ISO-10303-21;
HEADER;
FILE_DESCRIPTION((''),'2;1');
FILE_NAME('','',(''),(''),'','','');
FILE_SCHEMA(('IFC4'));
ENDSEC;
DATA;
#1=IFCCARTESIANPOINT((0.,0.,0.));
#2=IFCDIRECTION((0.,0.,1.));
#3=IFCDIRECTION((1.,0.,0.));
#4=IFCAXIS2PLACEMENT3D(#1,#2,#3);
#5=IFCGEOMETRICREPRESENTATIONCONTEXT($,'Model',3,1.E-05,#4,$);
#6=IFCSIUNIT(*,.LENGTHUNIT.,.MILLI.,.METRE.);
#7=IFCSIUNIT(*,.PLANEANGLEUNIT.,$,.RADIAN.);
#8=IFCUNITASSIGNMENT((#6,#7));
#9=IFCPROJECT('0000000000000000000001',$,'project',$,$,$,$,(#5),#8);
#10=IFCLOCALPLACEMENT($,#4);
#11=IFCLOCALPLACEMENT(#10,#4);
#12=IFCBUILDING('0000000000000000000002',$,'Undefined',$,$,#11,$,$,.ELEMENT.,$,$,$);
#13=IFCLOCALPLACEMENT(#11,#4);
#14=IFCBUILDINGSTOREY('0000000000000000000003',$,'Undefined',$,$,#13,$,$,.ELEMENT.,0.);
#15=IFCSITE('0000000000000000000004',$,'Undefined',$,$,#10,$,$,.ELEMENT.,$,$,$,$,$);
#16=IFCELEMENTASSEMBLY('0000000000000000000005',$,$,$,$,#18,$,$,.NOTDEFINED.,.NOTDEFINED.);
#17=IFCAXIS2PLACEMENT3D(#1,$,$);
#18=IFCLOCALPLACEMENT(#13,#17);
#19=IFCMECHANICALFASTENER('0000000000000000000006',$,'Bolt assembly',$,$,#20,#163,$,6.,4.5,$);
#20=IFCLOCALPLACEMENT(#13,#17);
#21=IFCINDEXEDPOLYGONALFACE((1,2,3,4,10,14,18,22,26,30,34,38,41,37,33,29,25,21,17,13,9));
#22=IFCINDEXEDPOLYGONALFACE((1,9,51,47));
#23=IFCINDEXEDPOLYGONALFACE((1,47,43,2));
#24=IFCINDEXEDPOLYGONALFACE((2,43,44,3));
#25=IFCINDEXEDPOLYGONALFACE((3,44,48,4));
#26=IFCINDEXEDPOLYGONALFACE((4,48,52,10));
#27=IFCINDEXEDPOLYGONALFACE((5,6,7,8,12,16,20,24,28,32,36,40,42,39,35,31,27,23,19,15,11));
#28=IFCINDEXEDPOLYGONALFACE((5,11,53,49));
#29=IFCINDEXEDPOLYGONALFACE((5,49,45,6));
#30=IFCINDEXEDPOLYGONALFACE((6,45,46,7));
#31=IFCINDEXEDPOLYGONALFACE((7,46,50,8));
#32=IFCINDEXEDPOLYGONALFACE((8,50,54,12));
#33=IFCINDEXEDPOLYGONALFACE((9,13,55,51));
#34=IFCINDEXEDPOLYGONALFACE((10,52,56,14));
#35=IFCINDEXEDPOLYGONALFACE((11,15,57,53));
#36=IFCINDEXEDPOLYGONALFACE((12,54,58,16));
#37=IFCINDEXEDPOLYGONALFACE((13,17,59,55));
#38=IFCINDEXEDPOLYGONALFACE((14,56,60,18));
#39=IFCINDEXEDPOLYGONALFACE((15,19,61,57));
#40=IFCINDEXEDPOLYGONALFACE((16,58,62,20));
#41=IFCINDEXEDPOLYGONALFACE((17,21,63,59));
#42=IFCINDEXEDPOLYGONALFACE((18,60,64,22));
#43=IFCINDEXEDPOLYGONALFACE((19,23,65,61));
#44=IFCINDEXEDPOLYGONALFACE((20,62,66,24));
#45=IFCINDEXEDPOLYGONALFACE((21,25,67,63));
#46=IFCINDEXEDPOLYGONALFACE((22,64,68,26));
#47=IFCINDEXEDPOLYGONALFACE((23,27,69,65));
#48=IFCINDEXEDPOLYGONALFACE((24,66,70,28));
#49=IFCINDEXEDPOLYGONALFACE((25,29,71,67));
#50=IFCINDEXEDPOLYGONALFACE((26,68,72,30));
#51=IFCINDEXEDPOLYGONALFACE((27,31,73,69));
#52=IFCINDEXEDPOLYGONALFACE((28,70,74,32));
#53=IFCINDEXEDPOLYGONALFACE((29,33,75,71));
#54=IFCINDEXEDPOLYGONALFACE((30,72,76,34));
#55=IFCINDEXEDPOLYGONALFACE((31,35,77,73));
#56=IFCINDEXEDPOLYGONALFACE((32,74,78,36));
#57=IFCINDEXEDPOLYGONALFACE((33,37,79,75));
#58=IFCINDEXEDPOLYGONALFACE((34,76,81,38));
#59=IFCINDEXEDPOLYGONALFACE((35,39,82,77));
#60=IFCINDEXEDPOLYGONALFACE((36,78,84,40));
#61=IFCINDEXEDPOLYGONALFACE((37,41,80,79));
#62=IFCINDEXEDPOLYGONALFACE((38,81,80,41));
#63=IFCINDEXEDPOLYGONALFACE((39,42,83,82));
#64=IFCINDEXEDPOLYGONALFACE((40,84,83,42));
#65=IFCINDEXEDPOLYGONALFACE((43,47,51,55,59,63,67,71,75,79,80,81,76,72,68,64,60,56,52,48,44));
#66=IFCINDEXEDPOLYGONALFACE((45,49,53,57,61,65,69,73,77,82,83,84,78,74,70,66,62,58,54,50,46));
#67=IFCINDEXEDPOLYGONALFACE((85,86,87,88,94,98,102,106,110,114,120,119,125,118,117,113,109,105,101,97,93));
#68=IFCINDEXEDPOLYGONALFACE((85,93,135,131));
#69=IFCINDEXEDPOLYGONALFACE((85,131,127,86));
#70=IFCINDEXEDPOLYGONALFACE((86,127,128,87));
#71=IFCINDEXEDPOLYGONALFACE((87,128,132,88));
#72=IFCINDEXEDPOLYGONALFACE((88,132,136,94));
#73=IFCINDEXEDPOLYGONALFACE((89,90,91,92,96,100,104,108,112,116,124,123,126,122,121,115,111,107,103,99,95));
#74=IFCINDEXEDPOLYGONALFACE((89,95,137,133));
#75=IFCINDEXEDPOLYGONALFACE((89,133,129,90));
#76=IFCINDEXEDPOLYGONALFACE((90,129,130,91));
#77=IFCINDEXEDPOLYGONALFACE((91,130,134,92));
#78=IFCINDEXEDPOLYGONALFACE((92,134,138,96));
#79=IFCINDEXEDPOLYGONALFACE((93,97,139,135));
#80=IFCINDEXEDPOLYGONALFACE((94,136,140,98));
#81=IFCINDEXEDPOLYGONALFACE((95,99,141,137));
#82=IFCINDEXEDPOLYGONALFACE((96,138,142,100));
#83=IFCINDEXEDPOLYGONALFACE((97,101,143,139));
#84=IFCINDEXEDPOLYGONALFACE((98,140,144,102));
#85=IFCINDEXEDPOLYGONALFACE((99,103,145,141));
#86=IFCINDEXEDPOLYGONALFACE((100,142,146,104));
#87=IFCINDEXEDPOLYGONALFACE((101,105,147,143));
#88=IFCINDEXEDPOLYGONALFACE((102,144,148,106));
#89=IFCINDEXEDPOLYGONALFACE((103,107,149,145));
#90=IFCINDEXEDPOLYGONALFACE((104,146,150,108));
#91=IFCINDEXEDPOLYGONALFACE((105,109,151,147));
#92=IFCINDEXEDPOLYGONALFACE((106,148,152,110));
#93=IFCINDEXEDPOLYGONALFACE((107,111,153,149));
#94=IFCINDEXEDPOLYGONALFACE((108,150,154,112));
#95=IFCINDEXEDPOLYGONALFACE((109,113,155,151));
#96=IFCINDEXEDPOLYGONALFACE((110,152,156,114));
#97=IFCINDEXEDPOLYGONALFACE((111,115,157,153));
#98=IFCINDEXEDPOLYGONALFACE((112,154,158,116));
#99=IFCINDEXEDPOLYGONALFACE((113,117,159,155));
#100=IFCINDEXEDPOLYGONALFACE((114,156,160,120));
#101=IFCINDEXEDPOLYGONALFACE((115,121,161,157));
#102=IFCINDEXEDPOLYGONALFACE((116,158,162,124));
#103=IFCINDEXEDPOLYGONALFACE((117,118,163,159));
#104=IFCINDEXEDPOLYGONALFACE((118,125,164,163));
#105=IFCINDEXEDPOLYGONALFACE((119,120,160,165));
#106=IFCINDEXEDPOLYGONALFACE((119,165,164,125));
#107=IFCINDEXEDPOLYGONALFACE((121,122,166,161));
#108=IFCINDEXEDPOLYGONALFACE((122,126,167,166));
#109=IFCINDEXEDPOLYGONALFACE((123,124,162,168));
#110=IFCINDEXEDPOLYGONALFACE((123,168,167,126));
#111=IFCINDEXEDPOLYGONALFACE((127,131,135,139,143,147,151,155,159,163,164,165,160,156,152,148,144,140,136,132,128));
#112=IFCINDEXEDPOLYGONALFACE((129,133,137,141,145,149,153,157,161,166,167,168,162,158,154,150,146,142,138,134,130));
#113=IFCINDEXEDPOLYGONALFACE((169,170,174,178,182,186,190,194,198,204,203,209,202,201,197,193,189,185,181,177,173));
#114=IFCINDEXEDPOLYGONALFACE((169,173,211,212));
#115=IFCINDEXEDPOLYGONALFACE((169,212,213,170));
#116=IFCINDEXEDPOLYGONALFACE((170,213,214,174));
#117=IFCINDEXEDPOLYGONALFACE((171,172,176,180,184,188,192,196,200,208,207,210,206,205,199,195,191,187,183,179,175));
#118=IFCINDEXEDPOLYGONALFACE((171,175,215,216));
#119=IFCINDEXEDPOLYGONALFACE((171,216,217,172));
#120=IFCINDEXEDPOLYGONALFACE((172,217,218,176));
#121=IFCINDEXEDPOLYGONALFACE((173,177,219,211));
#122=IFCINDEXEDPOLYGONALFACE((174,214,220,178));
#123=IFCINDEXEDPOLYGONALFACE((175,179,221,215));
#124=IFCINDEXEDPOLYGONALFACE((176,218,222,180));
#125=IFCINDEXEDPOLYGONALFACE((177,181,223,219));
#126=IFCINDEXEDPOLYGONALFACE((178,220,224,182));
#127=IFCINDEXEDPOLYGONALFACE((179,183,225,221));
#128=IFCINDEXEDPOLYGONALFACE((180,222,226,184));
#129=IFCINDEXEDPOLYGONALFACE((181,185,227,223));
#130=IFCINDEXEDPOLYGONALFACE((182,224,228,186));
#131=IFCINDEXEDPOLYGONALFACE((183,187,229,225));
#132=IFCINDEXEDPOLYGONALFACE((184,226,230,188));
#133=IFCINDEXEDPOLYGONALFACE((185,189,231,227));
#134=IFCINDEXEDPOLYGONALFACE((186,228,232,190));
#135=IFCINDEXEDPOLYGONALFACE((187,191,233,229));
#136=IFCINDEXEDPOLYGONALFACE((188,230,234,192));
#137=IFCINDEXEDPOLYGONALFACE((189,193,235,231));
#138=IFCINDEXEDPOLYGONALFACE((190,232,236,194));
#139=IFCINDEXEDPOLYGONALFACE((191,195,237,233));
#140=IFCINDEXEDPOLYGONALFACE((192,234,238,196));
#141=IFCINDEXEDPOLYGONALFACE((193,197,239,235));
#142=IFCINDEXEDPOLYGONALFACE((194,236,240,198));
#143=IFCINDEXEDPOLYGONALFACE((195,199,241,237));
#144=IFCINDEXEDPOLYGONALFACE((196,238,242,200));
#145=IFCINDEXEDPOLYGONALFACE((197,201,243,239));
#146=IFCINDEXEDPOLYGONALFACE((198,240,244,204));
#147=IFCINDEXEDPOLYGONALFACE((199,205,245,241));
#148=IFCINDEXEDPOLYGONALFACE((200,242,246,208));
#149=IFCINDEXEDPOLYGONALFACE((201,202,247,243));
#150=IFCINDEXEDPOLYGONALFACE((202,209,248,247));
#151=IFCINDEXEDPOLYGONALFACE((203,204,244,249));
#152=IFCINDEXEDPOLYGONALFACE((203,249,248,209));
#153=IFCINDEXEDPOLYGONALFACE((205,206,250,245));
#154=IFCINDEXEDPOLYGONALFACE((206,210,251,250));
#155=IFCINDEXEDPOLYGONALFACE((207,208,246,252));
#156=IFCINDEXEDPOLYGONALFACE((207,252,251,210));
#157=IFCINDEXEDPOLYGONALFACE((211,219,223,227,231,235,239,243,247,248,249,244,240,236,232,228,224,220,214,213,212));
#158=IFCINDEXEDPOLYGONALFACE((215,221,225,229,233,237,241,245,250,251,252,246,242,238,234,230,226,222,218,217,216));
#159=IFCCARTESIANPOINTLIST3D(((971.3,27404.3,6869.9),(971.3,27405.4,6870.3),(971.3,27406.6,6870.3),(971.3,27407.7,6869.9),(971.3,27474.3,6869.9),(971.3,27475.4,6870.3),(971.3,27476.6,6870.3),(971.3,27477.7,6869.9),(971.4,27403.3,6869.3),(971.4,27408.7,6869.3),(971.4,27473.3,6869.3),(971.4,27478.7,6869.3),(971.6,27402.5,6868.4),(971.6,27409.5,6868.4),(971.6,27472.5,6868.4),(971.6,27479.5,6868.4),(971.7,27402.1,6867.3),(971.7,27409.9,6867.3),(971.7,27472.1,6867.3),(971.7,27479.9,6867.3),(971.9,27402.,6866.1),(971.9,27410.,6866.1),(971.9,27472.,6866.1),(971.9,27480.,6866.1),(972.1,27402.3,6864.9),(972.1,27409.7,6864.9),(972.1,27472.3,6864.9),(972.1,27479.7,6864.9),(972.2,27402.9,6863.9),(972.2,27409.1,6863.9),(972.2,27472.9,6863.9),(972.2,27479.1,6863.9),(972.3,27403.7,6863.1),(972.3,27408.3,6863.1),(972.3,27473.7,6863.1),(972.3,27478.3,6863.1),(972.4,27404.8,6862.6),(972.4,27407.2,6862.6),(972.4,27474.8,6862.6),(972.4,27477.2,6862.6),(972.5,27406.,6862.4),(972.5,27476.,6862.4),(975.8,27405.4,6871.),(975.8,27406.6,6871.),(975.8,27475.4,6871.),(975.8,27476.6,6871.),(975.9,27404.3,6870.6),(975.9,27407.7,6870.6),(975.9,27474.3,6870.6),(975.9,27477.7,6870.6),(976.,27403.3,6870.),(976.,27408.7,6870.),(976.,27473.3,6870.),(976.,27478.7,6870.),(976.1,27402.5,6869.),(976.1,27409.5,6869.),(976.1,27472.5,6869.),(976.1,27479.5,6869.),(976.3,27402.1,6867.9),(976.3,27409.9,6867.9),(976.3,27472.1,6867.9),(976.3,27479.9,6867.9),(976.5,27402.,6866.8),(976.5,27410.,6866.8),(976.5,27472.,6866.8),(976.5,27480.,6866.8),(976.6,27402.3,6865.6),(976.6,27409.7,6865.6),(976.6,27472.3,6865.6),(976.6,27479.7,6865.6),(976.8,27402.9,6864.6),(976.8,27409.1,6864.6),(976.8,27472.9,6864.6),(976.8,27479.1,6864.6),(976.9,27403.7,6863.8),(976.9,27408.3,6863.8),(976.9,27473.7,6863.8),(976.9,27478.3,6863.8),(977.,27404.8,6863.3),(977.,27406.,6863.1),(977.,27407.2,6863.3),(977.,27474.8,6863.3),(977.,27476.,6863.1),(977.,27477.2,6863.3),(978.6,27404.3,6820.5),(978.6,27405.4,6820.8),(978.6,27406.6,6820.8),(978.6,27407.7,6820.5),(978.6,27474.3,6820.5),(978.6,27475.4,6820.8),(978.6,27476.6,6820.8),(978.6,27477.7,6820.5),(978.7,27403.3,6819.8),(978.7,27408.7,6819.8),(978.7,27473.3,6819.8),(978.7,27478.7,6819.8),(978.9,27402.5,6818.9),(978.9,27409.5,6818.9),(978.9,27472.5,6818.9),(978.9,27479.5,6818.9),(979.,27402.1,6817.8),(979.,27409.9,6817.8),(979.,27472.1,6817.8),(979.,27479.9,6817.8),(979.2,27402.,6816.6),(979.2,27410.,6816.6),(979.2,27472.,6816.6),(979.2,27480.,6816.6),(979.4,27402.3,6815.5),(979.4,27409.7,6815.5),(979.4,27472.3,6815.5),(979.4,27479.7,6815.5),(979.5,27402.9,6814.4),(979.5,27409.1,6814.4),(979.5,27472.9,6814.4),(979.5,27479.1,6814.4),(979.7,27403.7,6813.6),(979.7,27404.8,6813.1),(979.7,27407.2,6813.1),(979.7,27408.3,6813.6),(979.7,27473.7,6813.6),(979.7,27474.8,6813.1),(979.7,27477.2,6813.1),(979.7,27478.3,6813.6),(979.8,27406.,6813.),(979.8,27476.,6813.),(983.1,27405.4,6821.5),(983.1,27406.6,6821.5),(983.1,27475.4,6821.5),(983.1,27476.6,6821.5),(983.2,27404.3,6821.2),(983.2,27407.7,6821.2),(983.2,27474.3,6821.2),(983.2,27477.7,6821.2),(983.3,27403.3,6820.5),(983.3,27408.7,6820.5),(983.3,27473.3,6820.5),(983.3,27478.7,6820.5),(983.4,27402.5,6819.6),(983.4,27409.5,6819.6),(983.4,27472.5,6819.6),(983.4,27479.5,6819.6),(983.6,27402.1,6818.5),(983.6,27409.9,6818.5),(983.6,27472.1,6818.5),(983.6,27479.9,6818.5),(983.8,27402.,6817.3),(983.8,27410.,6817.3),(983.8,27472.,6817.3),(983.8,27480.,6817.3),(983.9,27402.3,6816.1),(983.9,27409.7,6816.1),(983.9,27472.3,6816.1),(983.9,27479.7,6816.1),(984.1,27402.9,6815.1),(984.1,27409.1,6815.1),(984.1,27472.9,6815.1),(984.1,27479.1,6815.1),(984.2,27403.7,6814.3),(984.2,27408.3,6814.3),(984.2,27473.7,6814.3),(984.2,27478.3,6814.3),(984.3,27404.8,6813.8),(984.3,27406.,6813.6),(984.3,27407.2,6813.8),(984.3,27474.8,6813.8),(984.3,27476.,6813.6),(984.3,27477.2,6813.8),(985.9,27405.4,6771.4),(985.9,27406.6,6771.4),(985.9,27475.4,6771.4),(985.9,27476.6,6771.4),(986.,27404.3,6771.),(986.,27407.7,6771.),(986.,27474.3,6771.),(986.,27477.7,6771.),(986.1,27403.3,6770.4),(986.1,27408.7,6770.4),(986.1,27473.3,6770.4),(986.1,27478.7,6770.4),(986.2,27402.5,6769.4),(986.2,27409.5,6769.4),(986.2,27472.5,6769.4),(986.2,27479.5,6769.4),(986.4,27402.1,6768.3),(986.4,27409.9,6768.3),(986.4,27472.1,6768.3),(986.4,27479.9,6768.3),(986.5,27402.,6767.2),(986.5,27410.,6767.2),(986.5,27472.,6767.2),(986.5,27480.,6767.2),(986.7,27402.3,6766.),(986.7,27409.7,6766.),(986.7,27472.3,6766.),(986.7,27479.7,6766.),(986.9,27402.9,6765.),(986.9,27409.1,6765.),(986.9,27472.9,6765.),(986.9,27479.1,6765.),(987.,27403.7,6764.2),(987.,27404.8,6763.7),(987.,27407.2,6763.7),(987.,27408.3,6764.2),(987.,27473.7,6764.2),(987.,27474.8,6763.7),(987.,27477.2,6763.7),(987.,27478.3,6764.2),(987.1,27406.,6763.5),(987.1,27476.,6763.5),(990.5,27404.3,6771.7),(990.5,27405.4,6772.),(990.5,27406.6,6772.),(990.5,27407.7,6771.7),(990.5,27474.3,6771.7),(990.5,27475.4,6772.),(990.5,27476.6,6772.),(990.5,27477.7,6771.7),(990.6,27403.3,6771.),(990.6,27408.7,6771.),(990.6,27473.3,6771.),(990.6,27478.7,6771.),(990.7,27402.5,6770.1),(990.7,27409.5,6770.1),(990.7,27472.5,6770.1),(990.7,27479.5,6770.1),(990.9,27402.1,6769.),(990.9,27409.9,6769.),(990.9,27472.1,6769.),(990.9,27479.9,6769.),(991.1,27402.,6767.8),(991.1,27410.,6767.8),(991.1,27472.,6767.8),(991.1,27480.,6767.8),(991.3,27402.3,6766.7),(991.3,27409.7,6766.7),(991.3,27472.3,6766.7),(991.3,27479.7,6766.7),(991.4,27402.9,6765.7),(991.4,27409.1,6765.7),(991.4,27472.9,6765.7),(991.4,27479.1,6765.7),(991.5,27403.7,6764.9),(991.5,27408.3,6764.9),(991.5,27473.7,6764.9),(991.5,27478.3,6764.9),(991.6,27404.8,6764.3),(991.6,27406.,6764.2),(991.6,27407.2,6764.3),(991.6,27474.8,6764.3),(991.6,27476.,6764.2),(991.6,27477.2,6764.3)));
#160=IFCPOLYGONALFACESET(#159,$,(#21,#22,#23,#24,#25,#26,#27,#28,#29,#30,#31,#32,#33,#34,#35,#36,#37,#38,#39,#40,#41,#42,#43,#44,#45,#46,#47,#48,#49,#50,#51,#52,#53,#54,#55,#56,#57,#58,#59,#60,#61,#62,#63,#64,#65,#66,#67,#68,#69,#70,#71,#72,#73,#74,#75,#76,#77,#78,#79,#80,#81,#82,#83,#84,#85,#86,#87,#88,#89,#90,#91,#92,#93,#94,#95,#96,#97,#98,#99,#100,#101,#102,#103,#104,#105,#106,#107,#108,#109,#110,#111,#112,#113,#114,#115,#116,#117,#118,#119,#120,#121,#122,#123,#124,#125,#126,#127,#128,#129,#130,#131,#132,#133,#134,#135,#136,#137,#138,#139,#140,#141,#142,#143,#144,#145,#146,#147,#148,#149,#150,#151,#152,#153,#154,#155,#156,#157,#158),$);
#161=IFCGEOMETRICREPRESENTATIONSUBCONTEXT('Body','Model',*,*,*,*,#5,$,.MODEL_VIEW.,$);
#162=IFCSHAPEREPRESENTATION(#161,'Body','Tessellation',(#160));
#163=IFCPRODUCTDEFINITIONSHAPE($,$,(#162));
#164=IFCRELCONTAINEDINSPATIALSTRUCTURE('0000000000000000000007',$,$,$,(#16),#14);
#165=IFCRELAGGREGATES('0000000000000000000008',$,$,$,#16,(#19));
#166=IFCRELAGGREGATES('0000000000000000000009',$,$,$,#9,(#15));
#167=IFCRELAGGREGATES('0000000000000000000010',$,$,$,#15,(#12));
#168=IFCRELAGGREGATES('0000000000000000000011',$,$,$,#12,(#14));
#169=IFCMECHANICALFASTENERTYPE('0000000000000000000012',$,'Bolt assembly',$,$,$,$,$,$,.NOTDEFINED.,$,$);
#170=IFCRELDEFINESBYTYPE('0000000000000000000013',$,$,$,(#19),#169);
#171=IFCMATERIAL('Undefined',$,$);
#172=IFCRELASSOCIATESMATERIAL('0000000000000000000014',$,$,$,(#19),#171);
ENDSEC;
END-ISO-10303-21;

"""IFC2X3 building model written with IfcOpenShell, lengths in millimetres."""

from ifc_helpers import new_model, si_unit, frame, origin_with_axes, origin_2d_with_axis, place, context, subcontext, project, spatial, circle, extrude, source, transform, mapped, material, type_object, element, aggregate, save


model = new_model("IFC2X3")

# Units and contexts
model_context = context("Model", 3, precision=1e-05, world=origin_with_axes())
body_context = subcontext(model_context, "Body", "Model", "MODEL_VIEW")
ifc_project = project(units=[si_unit("LENGTHUNIT", "METRE", prefix="MILLI"), si_unit("PLANEANGLEUNIT", "RADIAN")], contexts=[model_context])

# Site, building, storey
site_placement = place(None, origin_with_axes())
site = spatial("IfcSite", under=ifc_project, at=site_placement, Name="Undefined", CompositionType="ELEMENT")
building_placement = place(site_placement, origin_with_axes())
building = spatial("IfcBuilding", under=site, at=building_placement, Name="Undefined", CompositionType="ELEMENT")
storey_placement = place(building_placement, origin_with_axes())
storey = spatial("IfcBuildingStorey", under=building, at=storey_placement, Name="Undefined", CompositionType="ELEMENT", Elevation=0.0)

# Element assembly
assembly_1_placement = place(storey_placement, origin_with_axes())
assembly_1 = element("IfcElementAssembly", 1, at=assembly_1_placement, inside=storey, AssemblyPlace="NOTDEFINED", PredefinedType="NOTDEFINED")

# Mechanical fastener
ifc_material_1 = material(Name="Undefined")
mechanical_fastener_type = type_object("IfcMechanicalFastenerType", Name="Bolt assembly")
shared_shape_1 = source(origin_with_axes(), body_context, "Body", "SweptSolid", [
    extrude(circle(Radius=4.0, at=origin_2d_with_axis()), frame((0.0, 0.0, 0.0), z_axis=(0.0, 1.0, 0.0), x_axis=(1.0, 0.0, 0.0)), (0.0, 0.0, 1.0), 4.6),
])
mechanical_fastener_1_placement = place(assembly_1_placement, frame((971.9, 27441.0, 6866.4), z_axis=(0.0, -1.0, 0.0), x_axis=(0.146203, 0.0, -0.989255)))
mechanical_fastener_1 = element("IfcMechanicalFastener", 2, at=mechanical_fastener_1_placement, type_object=mechanical_fastener_type, material=ifc_material_1, Name="Bolt assembly", NominalDiameter=6.0, NominalLength=4.5, context=body_context, shape_type="MappedRepresentation", body=[
    mapped(shared_shape_1, transform((0.0, 0.0, -35.0))),
    mapped(shared_shape_1, transform((50.0, 0.0, -35.0))),
    mapped(shared_shape_1, transform((100.0, 0.0, -35.0))),
    mapped(shared_shape_1, transform((0.0, 0.0, 35.0))),
    mapped(shared_shape_1, transform((50.0, 0.0, 35.0))),
    mapped(shared_shape_1, transform((100.0, 0.0, 35.0))),
])

aggregate(assembly_1, [mechanical_fastener_1])

save(model, "model.ifc")
